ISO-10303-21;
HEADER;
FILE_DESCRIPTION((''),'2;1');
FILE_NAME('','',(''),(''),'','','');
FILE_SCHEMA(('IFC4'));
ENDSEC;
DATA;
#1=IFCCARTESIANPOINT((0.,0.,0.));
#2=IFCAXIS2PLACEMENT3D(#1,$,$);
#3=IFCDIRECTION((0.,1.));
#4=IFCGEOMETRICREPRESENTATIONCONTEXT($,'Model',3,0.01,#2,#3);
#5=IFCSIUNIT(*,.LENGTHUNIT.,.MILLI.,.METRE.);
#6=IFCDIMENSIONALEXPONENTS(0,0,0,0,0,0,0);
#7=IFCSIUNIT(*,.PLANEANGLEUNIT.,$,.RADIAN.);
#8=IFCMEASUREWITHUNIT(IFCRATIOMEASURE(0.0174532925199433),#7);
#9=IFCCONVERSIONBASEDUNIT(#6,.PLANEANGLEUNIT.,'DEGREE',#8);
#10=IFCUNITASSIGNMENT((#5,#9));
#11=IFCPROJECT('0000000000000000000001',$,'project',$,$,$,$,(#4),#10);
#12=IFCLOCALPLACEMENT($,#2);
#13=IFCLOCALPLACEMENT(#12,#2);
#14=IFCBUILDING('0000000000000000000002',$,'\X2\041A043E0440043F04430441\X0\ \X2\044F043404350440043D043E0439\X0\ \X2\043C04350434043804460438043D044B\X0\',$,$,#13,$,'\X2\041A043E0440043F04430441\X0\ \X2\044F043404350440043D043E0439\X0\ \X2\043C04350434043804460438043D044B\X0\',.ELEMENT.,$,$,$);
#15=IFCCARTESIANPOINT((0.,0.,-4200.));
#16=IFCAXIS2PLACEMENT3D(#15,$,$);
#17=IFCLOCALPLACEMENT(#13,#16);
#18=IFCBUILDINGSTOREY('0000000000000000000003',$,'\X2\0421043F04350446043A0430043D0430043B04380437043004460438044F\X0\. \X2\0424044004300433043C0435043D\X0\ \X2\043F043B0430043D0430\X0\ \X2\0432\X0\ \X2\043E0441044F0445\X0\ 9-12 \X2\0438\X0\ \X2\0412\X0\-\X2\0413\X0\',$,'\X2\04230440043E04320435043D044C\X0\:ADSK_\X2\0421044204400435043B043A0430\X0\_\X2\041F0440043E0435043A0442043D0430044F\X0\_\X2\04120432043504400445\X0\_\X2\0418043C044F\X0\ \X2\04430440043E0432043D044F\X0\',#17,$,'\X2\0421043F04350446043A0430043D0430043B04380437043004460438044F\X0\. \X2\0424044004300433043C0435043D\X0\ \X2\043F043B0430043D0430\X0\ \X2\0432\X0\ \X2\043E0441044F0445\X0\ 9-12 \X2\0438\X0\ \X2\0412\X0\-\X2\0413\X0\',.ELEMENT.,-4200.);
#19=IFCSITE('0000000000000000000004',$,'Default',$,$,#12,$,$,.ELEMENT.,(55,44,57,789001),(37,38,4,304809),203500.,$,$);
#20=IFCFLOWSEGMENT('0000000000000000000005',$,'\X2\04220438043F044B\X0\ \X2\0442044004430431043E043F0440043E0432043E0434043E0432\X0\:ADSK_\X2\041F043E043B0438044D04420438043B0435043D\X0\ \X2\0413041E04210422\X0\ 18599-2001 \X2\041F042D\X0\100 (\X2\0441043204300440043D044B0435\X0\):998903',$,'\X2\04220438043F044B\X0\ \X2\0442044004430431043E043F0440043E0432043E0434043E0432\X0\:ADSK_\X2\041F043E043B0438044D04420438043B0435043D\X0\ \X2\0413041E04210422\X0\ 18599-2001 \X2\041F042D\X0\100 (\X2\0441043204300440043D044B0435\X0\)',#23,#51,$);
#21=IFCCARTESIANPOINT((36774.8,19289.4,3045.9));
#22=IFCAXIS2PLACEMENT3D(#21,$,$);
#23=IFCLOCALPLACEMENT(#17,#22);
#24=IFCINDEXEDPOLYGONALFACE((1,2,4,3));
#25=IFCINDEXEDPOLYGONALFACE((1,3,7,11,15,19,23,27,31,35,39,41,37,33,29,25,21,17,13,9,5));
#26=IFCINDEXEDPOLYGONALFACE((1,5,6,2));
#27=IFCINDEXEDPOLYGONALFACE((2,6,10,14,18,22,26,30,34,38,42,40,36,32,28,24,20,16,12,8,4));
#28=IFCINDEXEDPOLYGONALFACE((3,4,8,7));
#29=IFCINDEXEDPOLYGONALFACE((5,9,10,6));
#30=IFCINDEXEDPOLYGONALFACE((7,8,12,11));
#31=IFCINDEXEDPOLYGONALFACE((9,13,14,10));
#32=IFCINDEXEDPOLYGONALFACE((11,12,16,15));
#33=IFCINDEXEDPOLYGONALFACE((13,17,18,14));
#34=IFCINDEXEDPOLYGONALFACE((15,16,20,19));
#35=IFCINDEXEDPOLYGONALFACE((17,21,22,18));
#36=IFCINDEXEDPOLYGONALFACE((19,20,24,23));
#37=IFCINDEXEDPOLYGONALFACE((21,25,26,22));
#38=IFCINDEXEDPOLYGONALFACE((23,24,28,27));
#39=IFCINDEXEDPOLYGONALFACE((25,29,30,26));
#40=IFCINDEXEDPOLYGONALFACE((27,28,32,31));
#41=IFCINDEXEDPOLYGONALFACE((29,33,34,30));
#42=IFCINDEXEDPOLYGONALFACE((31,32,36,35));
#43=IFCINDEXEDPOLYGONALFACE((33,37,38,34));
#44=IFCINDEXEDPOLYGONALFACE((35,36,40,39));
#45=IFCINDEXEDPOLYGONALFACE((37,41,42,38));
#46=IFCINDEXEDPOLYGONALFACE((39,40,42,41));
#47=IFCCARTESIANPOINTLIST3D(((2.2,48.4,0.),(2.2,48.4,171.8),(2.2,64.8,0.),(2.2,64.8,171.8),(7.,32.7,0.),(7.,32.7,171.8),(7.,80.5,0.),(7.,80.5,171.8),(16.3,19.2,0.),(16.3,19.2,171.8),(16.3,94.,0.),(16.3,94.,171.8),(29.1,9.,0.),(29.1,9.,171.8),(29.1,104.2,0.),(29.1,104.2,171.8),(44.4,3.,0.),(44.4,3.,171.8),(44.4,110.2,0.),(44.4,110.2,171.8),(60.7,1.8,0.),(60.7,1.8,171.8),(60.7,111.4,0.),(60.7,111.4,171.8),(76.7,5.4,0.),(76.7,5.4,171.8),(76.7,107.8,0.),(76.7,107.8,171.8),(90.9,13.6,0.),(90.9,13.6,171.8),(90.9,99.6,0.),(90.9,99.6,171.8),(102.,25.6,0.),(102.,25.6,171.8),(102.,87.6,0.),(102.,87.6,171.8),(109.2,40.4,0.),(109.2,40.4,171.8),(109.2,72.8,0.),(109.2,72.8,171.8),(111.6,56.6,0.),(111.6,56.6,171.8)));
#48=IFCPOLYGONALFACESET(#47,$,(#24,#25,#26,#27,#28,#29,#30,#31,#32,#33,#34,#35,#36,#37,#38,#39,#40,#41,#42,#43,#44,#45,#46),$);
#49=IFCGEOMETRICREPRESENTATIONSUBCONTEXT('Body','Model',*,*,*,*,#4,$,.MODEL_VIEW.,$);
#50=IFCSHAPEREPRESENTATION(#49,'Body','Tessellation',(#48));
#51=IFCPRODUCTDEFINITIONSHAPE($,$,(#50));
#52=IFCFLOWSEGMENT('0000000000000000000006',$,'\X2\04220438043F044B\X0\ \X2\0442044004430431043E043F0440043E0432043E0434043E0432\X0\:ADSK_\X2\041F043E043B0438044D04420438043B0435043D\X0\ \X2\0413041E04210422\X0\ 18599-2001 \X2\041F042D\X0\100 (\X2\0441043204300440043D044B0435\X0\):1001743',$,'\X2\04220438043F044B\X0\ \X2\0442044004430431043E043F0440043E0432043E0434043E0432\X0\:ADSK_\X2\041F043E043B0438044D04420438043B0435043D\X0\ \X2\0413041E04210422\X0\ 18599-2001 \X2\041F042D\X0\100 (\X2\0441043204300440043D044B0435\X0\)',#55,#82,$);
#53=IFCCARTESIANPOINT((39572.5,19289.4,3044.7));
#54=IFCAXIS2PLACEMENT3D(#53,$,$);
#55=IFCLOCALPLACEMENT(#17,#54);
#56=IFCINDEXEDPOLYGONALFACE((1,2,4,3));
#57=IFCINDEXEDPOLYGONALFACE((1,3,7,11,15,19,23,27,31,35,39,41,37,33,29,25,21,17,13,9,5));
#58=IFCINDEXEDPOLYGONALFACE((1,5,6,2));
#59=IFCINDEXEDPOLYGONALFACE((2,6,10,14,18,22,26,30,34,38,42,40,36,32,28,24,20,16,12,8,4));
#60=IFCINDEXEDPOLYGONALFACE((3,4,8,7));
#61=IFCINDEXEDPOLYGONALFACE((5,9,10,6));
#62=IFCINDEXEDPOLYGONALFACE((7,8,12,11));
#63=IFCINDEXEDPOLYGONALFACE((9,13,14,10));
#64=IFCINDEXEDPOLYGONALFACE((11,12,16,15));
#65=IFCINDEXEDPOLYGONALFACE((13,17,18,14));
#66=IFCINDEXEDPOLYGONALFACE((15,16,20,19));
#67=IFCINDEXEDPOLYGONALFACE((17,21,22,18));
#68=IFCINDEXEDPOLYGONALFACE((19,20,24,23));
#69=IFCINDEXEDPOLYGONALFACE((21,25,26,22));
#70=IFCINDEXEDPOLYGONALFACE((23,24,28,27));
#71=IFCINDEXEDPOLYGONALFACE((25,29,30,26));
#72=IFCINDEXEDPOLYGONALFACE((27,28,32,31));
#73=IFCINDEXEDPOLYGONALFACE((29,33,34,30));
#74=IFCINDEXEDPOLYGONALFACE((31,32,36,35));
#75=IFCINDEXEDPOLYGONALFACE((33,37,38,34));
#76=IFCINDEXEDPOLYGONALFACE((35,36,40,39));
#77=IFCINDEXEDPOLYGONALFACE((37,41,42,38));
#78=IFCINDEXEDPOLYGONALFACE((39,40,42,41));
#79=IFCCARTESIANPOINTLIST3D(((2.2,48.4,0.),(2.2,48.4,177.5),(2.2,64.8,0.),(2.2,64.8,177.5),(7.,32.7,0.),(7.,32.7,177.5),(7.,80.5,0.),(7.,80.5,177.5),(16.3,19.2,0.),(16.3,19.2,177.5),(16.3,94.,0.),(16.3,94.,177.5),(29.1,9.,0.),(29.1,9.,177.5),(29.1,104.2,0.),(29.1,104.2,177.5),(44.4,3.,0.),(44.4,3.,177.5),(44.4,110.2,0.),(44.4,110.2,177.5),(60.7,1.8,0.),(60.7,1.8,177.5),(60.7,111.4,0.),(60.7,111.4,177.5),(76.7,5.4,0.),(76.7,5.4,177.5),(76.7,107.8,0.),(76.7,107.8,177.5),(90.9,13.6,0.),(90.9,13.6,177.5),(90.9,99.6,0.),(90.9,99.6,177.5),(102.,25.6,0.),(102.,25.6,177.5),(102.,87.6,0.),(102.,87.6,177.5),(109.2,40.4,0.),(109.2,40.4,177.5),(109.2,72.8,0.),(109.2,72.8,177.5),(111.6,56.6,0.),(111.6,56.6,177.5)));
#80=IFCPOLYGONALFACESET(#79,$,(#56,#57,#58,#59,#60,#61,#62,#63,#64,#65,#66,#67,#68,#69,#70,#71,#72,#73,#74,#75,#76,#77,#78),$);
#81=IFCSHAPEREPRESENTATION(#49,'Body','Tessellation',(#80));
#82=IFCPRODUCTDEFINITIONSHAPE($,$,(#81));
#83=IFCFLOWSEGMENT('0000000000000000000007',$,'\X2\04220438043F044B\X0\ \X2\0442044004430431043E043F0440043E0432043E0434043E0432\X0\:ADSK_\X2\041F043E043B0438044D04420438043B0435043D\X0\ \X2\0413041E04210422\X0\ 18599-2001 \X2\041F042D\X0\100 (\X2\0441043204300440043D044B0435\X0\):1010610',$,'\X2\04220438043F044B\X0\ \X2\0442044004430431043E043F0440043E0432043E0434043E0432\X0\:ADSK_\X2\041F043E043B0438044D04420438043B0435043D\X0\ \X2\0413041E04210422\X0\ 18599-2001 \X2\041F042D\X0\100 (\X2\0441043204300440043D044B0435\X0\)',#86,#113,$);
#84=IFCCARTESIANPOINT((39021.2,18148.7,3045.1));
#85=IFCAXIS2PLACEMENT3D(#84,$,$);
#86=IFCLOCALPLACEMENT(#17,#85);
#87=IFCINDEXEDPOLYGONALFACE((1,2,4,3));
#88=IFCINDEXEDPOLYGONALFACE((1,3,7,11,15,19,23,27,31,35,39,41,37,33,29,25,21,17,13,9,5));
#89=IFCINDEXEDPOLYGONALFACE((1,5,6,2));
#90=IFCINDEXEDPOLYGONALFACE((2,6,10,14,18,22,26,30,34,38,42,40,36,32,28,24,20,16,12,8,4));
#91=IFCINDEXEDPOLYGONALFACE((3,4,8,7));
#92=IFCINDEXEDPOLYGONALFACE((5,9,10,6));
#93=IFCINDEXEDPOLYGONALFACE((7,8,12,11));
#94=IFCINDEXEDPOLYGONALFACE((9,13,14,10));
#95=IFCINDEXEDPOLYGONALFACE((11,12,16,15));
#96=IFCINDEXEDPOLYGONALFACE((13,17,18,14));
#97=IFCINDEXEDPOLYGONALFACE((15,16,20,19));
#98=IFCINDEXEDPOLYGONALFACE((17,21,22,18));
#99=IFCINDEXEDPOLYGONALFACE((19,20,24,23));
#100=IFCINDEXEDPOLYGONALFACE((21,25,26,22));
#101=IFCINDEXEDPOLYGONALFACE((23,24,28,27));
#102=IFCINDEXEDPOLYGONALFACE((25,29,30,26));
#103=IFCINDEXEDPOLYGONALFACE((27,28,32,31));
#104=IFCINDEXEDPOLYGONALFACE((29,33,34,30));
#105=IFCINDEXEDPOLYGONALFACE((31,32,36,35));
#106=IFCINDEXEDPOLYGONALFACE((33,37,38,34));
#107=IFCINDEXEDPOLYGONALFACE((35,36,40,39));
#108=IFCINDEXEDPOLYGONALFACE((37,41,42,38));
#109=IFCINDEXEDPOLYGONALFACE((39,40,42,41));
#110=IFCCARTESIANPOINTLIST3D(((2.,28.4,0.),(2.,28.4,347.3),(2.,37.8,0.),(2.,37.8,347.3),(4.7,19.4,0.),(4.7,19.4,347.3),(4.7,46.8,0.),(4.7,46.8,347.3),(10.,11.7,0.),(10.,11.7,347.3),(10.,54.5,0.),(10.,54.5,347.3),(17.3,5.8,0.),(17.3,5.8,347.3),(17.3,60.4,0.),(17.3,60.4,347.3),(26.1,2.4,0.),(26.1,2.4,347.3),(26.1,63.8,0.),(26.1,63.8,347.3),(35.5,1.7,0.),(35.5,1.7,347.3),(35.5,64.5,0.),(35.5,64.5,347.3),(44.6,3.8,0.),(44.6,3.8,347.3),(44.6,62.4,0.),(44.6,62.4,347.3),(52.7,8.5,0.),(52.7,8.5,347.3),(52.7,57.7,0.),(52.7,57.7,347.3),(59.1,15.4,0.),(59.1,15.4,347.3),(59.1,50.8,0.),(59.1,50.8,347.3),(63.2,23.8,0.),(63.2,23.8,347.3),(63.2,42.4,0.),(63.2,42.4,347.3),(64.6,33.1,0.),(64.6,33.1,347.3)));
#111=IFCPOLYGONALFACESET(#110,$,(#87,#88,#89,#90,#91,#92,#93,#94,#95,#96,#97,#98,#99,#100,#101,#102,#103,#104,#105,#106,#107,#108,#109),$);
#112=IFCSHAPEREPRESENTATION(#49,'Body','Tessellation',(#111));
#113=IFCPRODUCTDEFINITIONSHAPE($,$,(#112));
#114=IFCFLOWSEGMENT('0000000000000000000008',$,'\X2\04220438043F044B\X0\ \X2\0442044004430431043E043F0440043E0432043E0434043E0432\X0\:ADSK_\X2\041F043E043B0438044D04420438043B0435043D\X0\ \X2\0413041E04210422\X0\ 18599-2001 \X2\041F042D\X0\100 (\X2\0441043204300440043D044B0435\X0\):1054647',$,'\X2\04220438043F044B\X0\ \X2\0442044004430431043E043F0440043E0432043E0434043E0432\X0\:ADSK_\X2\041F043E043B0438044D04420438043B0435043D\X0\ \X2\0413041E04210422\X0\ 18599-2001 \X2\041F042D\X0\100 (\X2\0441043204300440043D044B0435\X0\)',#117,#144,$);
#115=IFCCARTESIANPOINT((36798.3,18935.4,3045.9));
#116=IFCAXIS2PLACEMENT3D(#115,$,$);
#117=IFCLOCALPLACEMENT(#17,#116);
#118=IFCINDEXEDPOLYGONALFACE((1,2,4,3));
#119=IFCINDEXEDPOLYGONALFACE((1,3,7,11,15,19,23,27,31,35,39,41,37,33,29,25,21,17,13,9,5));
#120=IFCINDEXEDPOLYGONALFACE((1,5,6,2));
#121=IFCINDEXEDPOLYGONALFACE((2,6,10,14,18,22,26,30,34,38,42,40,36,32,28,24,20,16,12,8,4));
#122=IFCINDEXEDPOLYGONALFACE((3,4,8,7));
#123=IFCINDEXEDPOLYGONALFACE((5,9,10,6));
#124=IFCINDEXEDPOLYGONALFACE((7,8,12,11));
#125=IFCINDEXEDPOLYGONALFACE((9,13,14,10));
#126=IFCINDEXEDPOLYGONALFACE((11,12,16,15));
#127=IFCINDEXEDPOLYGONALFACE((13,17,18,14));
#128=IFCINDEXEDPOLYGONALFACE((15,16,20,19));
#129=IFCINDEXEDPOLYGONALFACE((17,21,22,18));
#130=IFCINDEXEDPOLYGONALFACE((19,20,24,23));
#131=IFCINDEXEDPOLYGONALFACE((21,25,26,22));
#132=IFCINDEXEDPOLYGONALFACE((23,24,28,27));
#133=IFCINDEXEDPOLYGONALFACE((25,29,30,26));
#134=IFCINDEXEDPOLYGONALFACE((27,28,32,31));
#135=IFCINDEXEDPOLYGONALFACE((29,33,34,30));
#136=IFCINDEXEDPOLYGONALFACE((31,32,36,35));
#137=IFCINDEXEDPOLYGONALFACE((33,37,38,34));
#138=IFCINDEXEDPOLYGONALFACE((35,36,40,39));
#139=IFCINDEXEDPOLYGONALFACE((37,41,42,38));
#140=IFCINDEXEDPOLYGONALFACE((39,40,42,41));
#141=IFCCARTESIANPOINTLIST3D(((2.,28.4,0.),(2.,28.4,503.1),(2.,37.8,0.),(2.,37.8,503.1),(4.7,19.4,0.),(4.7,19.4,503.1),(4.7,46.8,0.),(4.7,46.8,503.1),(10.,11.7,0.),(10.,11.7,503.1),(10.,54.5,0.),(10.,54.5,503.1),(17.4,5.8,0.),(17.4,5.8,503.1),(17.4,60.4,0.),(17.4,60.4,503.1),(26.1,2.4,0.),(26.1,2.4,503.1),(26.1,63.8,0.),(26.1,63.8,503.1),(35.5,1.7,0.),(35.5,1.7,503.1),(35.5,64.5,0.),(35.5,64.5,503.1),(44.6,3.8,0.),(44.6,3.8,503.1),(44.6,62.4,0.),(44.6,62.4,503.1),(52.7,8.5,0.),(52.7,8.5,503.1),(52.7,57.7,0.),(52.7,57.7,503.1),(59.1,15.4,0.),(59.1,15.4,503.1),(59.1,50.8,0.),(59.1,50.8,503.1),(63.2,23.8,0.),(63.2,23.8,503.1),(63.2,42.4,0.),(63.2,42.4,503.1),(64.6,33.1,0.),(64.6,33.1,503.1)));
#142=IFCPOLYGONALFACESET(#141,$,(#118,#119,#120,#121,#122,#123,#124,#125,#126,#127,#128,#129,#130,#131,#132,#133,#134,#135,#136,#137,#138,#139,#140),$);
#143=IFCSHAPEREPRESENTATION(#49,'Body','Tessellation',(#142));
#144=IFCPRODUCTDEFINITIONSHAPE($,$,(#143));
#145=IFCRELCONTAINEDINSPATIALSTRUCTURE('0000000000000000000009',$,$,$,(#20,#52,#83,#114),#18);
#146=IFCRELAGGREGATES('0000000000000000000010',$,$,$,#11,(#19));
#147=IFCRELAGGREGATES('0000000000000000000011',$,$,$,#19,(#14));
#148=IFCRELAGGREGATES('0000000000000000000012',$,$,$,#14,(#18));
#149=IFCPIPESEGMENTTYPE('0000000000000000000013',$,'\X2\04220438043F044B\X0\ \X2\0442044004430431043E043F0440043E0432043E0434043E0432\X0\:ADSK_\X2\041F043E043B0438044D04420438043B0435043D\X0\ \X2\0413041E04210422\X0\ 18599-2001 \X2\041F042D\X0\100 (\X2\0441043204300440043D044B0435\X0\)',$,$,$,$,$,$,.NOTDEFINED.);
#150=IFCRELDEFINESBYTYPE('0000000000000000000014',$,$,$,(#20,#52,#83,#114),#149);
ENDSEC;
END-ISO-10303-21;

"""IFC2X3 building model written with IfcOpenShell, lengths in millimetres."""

from ifc_helpers import new_model, entity, si_unit, converted_unit, direction, frame, origin, origin_2d_with_axis, place, context, subcontext, project, spatial, circle, extrude, type_object, element, save


model = new_model("IFC2X3")

# Units and contexts
model_context = context("Model", 3, precision=0.01, world=origin(), true_north=direction((0.0, 1.0)))
body_context = subcontext(model_context, "Body", "Model", "MODEL_VIEW")
ifc_project = project(units=[si_unit("LENGTHUNIT", "METRE", prefix="MILLI"), converted_unit("PLANEANGLEUNIT", "DEGREE", entity("IfcRatioMeasure", 0.0174532925199433), si_unit("PLANEANGLEUNIT", "RADIAN"), dimensions=[0, 0, 0, 0, 0, 0, 0])], contexts=[model_context])

# Site, building, storey
site_placement = place(None, origin())
site = spatial("IfcSite", under=ifc_project, at=site_placement, Name="Default", CompositionType="ELEMENT", RefLatitude=(55, 44, 57, 789001), RefLongitude=(37, 38, 4, 304809), RefElevation=203500.0)
building_placement = place(site_placement, origin())
building = spatial("IfcBuilding", under=site, at=building_placement, Name="Корпус ядерной медицины", LongName="Корпус ядерной медицины", CompositionType="ELEMENT")
storey_placement = place(building_placement, frame((0.0, 0.0, -4200.0)))
storey = spatial("IfcBuildingStorey", under=building, at=storey_placement, Name="Спецканализация. Фрагмен плана в осях 9-12 и В-Г", ObjectType="Уровень:ADSK_Стрелка_Проектная_Вверх_Имя уровня", LongName="Спецканализация. Фрагмен плана в осях 9-12 и В-Г", CompositionType="ELEMENT", Elevation=-4200.0)

# Flow segments
pipe_segment_type = type_object("IfcPipeSegmentType", Name="Типы трубопроводов:ADSK_Полиэтилен ГОСТ 18599-2001 ПЭ100 (сварные)", PredefinedType="NOTDEFINED")
flow_segment_1_placement = place(storey_placement, frame((36774.8, 19289.4, 3045.9)))
element("IfcFlowSegment", 1, at=flow_segment_1_placement, inside=storey, type_object=pipe_segment_type, Name="Типы трубопроводов:ADSK_Полиэтилен ГОСТ 18599-2001 ПЭ100 (сварные):998903", ObjectType="Типы трубопроводов:ADSK_Полиэтилен ГОСТ 18599-2001 ПЭ100 (сварные)", context=body_context, shape_type="SweptSolid", body=[
    extrude(circle(Radius=55.0, at=origin_2d_with_axis()), frame((56.6, 56.6, 0.0)), (0.0, 0.0, 1.0), 171.8),
])
flow_segment_2_placement = place(storey_placement, frame((39572.5, 19289.4, 3044.7)))
element("IfcFlowSegment", 2, at=flow_segment_2_placement, inside=storey, type_object=pipe_segment_type, Name="Типы трубопроводов:ADSK_Полиэтилен ГОСТ 18599-2001 ПЭ100 (сварные):1001743", ObjectType="Типы трубопроводов:ADSK_Полиэтилен ГОСТ 18599-2001 ПЭ100 (сварные)", context=body_context, shape_type="SweptSolid", body=[
    extrude(circle(Radius=55.0, at=origin_2d_with_axis()), frame((56.6, 56.6, 0.0)), (0.0, 0.0, 1.0), 177.5),
])
flow_segment_3_placement = place(storey_placement, frame((39021.2, 18148.7, 3045.1)))
element("IfcFlowSegment", 3, at=flow_segment_3_placement, inside=storey, type_object=pipe_segment_type, Name="Типы трубопроводов:ADSK_Полиэтилен ГОСТ 18599-2001 ПЭ100 (сварные):1010610", ObjectType="Типы трубопроводов:ADSK_Полиэтилен ГОСТ 18599-2001 ПЭ100 (сварные)", context=body_context, shape_type="SweptSolid", body=[
    extrude(circle(Radius=31.5, at=origin_2d_with_axis()), frame((33.1, 33.1, 0.0)), (0.0, 0.0, 1.0), 347.3),
])
flow_segment_4_placement = place(storey_placement, frame((36798.3, 18935.4, 3045.9)))
element("IfcFlowSegment", 4, at=flow_segment_4_placement, inside=storey, type_object=pipe_segment_type, Name="Типы трубопроводов:ADSK_Полиэтилен ГОСТ 18599-2001 ПЭ100 (сварные):1054647", ObjectType="Типы трубопроводов:ADSK_Полиэтилен ГОСТ 18599-2001 ПЭ100 (сварные)", context=body_context, shape_type="SweptSolid", body=[
    extrude(circle(Radius=31.5, at=origin_2d_with_axis()), frame((33.1, 33.1, 0.0)), (0.0, 0.0, 1.0), 503.1),
])

save(model, "model.ifc")
